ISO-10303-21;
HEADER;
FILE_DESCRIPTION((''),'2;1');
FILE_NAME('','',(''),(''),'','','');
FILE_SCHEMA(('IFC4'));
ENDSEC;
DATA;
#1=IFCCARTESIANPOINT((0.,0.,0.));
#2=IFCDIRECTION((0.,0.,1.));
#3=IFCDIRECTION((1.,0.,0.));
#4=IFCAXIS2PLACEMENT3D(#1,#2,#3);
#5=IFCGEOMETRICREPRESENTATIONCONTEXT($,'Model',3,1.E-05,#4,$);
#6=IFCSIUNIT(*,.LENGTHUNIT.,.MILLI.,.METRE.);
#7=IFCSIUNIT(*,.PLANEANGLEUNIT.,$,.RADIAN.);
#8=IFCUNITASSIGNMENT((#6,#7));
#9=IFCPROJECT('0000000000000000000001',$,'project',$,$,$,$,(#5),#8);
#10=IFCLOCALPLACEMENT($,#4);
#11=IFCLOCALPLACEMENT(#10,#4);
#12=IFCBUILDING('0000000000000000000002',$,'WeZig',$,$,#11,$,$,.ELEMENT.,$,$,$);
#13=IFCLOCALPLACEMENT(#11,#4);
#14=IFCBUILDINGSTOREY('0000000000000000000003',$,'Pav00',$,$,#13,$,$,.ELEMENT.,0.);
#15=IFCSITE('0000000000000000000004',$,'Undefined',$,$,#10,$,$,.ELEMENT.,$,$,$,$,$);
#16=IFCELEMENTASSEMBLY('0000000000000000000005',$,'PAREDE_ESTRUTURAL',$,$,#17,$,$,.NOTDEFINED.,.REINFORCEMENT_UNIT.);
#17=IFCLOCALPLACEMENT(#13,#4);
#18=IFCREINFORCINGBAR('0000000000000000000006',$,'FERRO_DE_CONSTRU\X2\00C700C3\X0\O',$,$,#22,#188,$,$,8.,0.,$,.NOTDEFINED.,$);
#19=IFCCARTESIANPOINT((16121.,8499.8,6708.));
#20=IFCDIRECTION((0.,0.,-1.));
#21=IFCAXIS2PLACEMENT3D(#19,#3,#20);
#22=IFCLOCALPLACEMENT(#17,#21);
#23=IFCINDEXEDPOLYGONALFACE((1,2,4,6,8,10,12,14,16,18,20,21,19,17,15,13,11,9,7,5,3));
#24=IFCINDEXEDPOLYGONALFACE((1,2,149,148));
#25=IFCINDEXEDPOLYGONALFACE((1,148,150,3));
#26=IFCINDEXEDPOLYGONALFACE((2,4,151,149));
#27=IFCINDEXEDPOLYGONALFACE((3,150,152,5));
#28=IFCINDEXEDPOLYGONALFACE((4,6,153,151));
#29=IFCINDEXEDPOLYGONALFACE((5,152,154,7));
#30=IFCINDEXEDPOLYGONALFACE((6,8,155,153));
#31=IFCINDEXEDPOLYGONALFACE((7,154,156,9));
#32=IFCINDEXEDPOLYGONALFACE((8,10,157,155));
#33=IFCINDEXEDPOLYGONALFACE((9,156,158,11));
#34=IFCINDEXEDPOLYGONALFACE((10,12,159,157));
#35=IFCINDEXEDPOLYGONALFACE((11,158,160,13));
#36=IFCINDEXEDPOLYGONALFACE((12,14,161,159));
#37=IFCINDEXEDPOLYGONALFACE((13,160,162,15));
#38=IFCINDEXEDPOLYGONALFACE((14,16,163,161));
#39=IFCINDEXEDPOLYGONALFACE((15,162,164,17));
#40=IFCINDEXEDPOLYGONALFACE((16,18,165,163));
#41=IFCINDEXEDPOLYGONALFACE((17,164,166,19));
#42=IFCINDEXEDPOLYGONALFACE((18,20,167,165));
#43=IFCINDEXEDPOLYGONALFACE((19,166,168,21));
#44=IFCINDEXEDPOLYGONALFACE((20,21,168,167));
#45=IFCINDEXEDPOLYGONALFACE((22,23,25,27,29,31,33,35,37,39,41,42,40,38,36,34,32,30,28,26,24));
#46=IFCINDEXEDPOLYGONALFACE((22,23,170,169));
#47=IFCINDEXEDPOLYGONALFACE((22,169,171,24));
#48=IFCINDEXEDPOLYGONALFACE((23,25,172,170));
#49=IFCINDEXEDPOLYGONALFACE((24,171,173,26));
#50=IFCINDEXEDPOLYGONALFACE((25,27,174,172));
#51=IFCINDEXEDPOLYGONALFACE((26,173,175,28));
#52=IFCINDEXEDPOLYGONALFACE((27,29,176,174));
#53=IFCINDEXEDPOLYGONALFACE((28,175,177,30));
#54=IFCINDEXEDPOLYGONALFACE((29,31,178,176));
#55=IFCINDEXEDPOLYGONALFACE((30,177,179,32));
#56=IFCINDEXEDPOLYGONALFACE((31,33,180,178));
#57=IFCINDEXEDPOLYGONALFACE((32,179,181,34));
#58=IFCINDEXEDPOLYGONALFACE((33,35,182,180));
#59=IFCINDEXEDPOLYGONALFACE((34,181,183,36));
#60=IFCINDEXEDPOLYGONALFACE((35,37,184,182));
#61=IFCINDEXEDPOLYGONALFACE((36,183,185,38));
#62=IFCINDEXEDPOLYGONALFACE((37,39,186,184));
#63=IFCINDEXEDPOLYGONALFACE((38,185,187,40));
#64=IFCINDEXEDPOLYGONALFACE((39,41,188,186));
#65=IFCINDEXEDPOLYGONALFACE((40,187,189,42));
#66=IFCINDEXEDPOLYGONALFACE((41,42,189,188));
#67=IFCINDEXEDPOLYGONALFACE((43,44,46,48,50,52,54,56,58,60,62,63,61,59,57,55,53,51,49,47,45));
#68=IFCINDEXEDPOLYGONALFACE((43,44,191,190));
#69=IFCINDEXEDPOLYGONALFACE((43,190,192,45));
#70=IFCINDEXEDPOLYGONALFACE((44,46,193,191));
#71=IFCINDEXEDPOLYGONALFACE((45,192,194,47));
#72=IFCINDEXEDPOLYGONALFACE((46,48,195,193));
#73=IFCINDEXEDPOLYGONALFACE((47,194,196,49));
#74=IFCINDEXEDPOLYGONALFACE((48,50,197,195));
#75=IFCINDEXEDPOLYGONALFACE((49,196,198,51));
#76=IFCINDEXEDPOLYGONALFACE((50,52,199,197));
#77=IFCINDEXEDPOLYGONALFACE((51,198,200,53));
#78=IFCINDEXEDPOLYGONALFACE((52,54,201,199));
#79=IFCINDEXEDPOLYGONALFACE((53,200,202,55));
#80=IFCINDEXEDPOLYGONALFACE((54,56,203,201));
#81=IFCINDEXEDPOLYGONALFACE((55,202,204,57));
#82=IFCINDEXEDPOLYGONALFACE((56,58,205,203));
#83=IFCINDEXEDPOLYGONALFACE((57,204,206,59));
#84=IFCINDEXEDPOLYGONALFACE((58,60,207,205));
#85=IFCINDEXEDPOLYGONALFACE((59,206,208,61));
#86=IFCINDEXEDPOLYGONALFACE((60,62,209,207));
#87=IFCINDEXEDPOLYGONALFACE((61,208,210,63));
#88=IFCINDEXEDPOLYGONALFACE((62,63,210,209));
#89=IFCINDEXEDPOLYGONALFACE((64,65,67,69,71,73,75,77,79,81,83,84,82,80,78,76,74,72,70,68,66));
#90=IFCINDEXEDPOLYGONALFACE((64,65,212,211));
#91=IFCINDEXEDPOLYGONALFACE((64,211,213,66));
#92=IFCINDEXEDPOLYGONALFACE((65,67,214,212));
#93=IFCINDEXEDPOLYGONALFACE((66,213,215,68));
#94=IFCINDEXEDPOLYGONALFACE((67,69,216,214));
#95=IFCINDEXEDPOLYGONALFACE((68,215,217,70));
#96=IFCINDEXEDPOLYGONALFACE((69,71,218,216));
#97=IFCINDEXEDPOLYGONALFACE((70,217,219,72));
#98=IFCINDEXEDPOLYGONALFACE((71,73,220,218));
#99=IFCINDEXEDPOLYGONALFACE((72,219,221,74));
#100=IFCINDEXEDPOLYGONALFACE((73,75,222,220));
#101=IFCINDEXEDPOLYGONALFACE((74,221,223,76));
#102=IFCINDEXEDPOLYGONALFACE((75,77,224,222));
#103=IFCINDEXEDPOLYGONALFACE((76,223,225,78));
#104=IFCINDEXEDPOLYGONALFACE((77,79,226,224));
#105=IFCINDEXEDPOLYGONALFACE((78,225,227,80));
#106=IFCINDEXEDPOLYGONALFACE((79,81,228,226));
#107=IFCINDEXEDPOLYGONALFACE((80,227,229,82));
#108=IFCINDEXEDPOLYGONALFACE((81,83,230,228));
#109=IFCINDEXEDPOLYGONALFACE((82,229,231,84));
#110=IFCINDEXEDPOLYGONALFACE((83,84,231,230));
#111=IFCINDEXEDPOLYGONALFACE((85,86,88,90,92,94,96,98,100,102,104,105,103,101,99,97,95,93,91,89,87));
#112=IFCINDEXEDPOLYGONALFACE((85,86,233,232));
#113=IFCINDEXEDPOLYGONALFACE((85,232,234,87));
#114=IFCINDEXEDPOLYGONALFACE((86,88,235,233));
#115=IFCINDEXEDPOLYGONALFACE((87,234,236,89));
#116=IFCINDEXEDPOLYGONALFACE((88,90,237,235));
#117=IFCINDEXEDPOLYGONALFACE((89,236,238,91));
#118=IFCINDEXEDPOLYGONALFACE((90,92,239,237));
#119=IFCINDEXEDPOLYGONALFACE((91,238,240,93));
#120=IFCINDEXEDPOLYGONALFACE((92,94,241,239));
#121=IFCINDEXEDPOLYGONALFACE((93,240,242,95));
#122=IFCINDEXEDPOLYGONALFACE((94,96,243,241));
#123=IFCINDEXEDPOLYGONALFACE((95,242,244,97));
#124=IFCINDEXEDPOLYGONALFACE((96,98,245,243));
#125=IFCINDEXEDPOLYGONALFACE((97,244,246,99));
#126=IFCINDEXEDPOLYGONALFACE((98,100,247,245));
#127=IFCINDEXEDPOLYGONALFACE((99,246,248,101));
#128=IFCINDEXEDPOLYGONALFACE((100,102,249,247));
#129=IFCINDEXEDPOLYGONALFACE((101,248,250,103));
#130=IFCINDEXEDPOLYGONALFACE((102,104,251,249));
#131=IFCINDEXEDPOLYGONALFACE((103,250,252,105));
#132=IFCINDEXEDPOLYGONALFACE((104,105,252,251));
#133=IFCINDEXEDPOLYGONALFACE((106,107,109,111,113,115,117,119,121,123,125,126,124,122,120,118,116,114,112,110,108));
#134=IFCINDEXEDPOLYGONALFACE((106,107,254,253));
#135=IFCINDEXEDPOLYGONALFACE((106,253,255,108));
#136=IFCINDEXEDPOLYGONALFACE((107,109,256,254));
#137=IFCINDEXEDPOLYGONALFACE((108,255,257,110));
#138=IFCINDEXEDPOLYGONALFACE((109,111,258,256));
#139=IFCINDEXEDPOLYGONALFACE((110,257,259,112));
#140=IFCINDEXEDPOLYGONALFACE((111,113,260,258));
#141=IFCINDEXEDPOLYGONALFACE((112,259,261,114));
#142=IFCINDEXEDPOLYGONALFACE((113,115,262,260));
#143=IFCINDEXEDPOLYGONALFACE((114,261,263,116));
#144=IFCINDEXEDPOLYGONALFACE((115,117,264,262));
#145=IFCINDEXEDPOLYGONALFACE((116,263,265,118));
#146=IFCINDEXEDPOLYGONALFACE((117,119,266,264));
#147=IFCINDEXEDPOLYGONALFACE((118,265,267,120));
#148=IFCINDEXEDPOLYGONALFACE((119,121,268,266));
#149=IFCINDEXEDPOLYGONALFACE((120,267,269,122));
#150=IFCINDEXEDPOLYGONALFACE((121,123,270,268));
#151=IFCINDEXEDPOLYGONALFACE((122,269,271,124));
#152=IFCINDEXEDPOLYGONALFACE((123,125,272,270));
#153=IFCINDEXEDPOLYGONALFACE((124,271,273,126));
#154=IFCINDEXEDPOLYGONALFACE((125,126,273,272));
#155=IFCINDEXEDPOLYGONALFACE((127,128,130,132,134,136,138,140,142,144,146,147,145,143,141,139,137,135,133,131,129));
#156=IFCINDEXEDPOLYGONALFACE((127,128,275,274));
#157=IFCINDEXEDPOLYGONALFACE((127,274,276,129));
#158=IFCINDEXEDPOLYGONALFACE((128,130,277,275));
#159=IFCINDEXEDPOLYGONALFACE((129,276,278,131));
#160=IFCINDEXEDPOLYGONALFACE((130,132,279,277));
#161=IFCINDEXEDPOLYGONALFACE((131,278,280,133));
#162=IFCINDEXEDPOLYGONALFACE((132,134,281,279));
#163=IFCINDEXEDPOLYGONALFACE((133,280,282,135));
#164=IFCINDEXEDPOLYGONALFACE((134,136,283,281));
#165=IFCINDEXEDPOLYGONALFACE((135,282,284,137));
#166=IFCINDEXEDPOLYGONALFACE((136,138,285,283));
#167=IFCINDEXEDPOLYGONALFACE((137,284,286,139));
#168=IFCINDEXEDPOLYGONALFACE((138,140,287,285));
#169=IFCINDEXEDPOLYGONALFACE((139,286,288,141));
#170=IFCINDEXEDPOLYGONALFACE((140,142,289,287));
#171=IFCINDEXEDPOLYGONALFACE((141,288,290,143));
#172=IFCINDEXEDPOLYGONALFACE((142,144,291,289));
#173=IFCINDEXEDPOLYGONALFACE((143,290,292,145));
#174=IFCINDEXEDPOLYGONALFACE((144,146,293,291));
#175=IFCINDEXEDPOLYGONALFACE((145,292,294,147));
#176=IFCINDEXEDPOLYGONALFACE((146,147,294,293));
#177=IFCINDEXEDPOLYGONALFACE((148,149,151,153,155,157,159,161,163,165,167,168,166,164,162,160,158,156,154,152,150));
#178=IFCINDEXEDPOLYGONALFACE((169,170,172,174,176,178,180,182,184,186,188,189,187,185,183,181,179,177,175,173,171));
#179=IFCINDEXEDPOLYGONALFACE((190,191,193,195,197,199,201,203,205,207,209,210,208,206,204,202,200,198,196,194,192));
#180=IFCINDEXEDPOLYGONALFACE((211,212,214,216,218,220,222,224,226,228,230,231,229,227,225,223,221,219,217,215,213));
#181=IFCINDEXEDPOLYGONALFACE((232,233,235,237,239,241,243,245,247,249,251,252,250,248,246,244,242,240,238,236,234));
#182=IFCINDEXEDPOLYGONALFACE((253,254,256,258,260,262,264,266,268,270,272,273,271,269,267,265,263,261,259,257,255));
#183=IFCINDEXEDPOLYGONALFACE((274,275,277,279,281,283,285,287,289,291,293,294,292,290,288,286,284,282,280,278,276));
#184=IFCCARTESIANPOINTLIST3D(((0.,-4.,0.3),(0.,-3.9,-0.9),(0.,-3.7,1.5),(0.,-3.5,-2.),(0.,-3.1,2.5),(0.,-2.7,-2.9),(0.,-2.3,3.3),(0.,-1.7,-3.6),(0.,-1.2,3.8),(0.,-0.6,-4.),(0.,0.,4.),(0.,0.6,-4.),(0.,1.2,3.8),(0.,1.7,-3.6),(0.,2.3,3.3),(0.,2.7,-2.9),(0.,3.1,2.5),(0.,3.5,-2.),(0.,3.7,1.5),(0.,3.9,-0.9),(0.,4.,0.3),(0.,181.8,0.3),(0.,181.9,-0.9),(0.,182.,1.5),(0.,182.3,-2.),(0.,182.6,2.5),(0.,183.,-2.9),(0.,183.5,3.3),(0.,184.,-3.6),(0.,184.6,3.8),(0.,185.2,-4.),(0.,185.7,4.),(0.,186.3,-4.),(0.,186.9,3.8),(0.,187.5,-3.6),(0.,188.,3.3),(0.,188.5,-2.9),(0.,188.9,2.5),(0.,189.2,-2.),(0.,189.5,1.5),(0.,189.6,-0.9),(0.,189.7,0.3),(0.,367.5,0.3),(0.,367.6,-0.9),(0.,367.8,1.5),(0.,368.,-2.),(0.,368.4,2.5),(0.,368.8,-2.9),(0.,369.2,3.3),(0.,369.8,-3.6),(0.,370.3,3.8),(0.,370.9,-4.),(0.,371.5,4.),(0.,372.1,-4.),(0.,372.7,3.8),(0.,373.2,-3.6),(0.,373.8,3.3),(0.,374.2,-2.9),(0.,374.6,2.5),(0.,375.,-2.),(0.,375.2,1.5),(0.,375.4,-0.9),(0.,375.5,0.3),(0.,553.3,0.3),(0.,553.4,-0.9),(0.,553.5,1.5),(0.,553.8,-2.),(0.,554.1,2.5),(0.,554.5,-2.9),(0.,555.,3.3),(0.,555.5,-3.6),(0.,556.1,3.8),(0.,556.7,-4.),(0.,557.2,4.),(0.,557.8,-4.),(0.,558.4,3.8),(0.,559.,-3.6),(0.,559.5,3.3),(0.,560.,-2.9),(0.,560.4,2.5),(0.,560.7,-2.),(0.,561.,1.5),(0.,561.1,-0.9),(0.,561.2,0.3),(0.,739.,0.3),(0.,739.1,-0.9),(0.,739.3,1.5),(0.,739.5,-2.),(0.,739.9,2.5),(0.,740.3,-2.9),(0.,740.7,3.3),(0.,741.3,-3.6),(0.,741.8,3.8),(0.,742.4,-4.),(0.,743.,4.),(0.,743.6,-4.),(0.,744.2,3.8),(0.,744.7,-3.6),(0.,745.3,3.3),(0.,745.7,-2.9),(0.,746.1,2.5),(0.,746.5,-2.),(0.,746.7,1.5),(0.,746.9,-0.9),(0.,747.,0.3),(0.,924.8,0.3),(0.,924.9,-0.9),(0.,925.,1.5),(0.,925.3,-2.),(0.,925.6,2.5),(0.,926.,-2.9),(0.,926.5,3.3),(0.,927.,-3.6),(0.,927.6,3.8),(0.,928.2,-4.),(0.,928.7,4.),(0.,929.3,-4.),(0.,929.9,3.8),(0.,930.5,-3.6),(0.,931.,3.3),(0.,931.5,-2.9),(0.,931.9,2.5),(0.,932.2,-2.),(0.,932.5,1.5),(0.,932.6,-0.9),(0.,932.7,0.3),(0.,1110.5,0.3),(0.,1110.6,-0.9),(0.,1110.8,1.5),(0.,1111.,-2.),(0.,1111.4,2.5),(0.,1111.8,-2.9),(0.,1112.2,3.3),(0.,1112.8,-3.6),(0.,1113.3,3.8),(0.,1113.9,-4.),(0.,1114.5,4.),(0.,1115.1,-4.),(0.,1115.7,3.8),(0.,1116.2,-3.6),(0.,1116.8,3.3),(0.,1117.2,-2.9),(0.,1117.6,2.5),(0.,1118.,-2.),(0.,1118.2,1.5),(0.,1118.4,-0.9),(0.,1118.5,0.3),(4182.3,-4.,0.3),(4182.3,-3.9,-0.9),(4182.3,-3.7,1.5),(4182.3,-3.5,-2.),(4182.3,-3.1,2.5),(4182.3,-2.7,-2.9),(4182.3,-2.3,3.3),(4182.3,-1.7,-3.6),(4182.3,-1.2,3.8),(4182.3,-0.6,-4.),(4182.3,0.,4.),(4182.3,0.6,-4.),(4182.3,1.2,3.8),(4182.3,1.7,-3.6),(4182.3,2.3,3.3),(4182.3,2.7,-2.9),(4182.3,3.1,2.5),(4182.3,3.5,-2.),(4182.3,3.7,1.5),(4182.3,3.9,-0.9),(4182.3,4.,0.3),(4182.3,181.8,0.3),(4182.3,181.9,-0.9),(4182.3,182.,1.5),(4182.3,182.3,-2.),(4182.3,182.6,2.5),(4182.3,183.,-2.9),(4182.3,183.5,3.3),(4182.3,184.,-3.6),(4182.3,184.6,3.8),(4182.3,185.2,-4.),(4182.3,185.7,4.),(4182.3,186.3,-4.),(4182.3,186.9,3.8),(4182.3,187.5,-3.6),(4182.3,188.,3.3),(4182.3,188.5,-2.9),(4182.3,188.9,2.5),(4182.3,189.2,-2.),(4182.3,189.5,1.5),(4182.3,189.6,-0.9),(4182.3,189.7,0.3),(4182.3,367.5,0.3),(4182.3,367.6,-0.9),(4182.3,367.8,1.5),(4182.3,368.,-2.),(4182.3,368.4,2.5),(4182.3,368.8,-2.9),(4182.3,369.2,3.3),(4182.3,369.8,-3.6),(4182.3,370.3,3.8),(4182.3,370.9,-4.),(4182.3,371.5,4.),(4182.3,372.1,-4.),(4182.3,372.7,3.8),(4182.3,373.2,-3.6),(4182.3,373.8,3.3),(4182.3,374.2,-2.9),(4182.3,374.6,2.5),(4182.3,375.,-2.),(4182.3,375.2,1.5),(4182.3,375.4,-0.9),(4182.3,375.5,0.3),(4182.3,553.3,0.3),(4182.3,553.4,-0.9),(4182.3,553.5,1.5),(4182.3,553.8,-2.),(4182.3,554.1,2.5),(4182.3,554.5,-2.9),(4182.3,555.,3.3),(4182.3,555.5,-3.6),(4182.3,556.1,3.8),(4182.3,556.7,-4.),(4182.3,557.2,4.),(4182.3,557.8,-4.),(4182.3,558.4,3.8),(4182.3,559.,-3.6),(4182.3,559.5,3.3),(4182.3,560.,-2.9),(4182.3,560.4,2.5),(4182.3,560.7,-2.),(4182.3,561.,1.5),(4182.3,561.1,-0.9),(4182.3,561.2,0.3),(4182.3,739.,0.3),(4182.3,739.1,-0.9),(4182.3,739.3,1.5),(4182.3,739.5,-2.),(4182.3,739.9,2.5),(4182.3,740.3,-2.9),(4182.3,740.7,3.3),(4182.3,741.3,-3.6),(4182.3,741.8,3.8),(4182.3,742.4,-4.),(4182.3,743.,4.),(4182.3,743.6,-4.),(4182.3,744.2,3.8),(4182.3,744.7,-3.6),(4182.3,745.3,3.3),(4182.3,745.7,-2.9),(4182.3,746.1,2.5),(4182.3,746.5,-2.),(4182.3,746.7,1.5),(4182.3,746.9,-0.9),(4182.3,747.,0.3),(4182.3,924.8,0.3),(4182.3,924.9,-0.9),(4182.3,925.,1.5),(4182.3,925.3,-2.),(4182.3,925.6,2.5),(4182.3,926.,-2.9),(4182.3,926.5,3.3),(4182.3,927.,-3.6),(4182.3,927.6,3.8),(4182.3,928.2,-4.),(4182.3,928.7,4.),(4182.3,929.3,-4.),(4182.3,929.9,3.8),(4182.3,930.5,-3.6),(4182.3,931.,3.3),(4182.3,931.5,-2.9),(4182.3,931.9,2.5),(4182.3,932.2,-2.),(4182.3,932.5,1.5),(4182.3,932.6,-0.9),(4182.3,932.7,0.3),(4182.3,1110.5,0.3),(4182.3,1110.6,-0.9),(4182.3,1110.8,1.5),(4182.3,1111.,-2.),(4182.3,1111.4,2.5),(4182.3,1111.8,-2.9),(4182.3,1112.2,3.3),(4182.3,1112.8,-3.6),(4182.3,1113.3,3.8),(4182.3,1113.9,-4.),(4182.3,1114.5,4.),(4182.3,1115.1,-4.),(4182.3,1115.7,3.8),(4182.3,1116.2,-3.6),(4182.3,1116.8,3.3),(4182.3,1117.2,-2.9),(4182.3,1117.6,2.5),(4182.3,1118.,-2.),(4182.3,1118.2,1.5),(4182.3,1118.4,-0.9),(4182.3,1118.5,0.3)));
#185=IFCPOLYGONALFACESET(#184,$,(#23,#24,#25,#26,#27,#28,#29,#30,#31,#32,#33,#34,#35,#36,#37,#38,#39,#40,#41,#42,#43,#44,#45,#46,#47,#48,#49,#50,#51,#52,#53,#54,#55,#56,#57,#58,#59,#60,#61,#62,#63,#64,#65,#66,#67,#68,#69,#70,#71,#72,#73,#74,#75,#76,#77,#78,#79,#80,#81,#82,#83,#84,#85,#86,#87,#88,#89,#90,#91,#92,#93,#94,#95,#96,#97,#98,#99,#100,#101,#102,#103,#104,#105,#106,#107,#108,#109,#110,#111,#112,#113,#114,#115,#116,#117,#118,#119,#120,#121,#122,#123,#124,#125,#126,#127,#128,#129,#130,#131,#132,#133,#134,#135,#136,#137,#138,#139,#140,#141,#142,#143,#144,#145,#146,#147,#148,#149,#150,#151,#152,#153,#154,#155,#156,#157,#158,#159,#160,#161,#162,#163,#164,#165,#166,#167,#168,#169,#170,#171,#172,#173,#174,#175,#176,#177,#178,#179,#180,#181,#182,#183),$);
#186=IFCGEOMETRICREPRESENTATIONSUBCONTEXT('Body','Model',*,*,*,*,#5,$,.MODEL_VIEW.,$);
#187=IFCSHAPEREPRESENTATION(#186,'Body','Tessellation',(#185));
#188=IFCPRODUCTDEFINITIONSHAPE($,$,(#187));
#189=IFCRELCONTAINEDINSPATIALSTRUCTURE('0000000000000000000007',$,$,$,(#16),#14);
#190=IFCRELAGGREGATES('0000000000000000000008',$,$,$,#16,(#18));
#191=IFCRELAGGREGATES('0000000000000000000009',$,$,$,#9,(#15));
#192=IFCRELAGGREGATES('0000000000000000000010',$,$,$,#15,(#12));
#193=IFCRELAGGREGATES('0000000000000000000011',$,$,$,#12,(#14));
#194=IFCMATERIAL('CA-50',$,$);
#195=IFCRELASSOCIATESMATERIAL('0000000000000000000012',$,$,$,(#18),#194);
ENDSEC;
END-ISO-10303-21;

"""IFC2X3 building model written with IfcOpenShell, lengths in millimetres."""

from ifc_helpers import new_model, entity, si_unit, frame, origin_with_axes, place, context, subcontext, project, spatial, source, transform, mapped, material, element, aggregate, save


model = new_model("IFC2X3")

# Units and contexts
model_context = context("Model", 3, precision=1e-05, world=origin_with_axes())
body_context = subcontext(model_context, "Body", "Model", "MODEL_VIEW")
ifc_project = project(units=[si_unit("LENGTHUNIT", "METRE", prefix="MILLI"), si_unit("PLANEANGLEUNIT", "RADIAN")], contexts=[model_context])

# Site, building, storey
site_placement = place(None, origin_with_axes())
site = spatial("IfcSite", under=ifc_project, at=site_placement, Name="Undefined", CompositionType="ELEMENT")
building_placement = place(site_placement, origin_with_axes())
building = spatial("IfcBuilding", under=site, at=building_placement, Name="WeZig", CompositionType="ELEMENT")
storey_placement = place(building_placement, origin_with_axes())
storey = spatial("IfcBuildingStorey", under=building, at=storey_placement, Name="Pav00", CompositionType="ELEMENT", Elevation=0.0)

# Element assembly
assembly_1_placement = place(storey_placement, origin_with_axes())
assembly_1 = element("IfcElementAssembly", 1, at=assembly_1_placement, inside=storey, Name="PAREDE_ESTRUTURAL", AssemblyPlace="NOTDEFINED", PredefinedType="REINFORCEMENT_UNIT")

# Reinforcing bar
ifc_material_1 = material(Name="CA-50")
shared_shape_1 = source(origin_with_axes(), body_context, "Body", "AdvancedSweptSolid", [
    entity("IfcSweptDiskSolid", entity("IfcTrimmedCurve", entity("IfcLine", entity("IfcCartesianPoint", [0.0, 0.0, 0.0]), entity("IfcVector", entity("IfcDirection", [1.0, 0.0, 0.0]), 1.0)), [entity("IfcParameterValue", 0.0)], [entity("IfcParameterValue", 4182.303895)], True, "PARAMETER"), 4.0, None, 0.0, 4182.3),
])
shared_shape_2 = source(origin_with_axes(), body_context, "Body", "AdvancedSweptSolid", [
    entity("IfcSweptDiskSolid", entity("IfcTrimmedCurve", entity("IfcLine", entity("IfcCartesianPoint", [0.0, 0.0, 0.0]), entity("IfcVector", entity("IfcDirection", [1.0, 0.0, 0.0]), 1.0)), [entity("IfcParameterValue", 0.0)], [entity("IfcParameterValue", 4182.303895)], True, "PARAMETER"), 4.0, None, 0.0, 4182.3),
])
shared_shape_3 = source(origin_with_axes(), body_context, "Body", "AdvancedSweptSolid", [
    entity("IfcSweptDiskSolid", entity("IfcTrimmedCurve", entity("IfcLine", entity("IfcCartesianPoint", [0.0, 0.0, 0.0]), entity("IfcVector", entity("IfcDirection", [1.0, 0.0, 0.0]), 1.0)), [entity("IfcParameterValue", 0.0)], [entity("IfcParameterValue", 4182.303895)], True, "PARAMETER"), 4.0, None, 0.0, 4182.3),
])
shared_shape_4 = source(origin_with_axes(), body_context, "Body", "AdvancedSweptSolid", [
    entity("IfcSweptDiskSolid", entity("IfcTrimmedCurve", entity("IfcLine", entity("IfcCartesianPoint", [0.0, 0.0, 0.0]), entity("IfcVector", entity("IfcDirection", [1.0, 0.0, 0.0]), 1.0)), [entity("IfcParameterValue", 0.0)], [entity("IfcParameterValue", 4182.303895)], True, "PARAMETER"), 4.0, None, 0.0, 4182.3),
])
shared_shape_5 = source(origin_with_axes(), body_context, "Body", "AdvancedSweptSolid", [
    entity("IfcSweptDiskSolid", entity("IfcTrimmedCurve", entity("IfcLine", entity("IfcCartesianPoint", [0.0, 0.0, 0.0]), entity("IfcVector", entity("IfcDirection", [1.0, 0.0, 0.0]), 1.0)), [entity("IfcParameterValue", 0.0)], [entity("IfcParameterValue", 4182.303895)], True, "PARAMETER"), 4.0, None, 0.0, 4182.3),
])
shared_shape_6 = source(origin_with_axes(), body_context, "Body", "AdvancedSweptSolid", [
    entity("IfcSweptDiskSolid", entity("IfcTrimmedCurve", entity("IfcLine", entity("IfcCartesianPoint", [0.0, 0.0, 0.0]), entity("IfcVector", entity("IfcDirection", [1.0, 0.0, 0.0]), 1.0)), [entity("IfcParameterValue", 0.0)], [entity("IfcParameterValue", 4182.303895)], True, "PARAMETER"), 4.0, None, 0.0, 4182.3),
])
shared_shape_7 = source(origin_with_axes(), body_context, "Body", "AdvancedSweptSolid", [
    entity("IfcSweptDiskSolid", entity("IfcTrimmedCurve", entity("IfcLine", entity("IfcCartesianPoint", [0.0, 0.0, 0.0]), entity("IfcVector", entity("IfcDirection", [1.0, 0.0, 0.0]), 1.0)), [entity("IfcParameterValue", 0.0)], [entity("IfcParameterValue", 4182.303895)], True, "PARAMETER"), 4.0, None, 0.0, 4182.3),
])
reinforcing_bar_1_placement = place(assembly_1_placement, frame((16121.0, 8499.8, 6708.0), z_axis=(1.0, 0.0, 0.0), x_axis=(0.0, 0.0, -1.0)))
reinforcing_bar_1 = element("IfcReinforcingBar", 2, at=reinforcing_bar_1_placement, material=ifc_material_1, Name="FERRO_DE_CONSTRUÇÃO", BarRole="NOTDEFINED", CrossSectionArea=0.0, NominalDiameter=8.0, context=body_context, shape_type="MappedRepresentation", body=[
    mapped(shared_shape_1, transform((0.0, 0.0, 0.0))),
    mapped(shared_shape_2, transform((0.0, 185.7, 0.0))),
    mapped(shared_shape_3, transform((0.0, 371.5, 0.0))),
    mapped(shared_shape_4, transform((0.0, 557.2, 0.0))),
    mapped(shared_shape_5, transform((0.0, 743.0, 0.0))),
    mapped(shared_shape_6, transform((0.0, 928.7, 0.0))),
    mapped(shared_shape_7, transform((0.0, 1114.5, 0.0))),
])
aggregate(assembly_1, [reinforcing_bar_1])

save(model, "model.ifc")
